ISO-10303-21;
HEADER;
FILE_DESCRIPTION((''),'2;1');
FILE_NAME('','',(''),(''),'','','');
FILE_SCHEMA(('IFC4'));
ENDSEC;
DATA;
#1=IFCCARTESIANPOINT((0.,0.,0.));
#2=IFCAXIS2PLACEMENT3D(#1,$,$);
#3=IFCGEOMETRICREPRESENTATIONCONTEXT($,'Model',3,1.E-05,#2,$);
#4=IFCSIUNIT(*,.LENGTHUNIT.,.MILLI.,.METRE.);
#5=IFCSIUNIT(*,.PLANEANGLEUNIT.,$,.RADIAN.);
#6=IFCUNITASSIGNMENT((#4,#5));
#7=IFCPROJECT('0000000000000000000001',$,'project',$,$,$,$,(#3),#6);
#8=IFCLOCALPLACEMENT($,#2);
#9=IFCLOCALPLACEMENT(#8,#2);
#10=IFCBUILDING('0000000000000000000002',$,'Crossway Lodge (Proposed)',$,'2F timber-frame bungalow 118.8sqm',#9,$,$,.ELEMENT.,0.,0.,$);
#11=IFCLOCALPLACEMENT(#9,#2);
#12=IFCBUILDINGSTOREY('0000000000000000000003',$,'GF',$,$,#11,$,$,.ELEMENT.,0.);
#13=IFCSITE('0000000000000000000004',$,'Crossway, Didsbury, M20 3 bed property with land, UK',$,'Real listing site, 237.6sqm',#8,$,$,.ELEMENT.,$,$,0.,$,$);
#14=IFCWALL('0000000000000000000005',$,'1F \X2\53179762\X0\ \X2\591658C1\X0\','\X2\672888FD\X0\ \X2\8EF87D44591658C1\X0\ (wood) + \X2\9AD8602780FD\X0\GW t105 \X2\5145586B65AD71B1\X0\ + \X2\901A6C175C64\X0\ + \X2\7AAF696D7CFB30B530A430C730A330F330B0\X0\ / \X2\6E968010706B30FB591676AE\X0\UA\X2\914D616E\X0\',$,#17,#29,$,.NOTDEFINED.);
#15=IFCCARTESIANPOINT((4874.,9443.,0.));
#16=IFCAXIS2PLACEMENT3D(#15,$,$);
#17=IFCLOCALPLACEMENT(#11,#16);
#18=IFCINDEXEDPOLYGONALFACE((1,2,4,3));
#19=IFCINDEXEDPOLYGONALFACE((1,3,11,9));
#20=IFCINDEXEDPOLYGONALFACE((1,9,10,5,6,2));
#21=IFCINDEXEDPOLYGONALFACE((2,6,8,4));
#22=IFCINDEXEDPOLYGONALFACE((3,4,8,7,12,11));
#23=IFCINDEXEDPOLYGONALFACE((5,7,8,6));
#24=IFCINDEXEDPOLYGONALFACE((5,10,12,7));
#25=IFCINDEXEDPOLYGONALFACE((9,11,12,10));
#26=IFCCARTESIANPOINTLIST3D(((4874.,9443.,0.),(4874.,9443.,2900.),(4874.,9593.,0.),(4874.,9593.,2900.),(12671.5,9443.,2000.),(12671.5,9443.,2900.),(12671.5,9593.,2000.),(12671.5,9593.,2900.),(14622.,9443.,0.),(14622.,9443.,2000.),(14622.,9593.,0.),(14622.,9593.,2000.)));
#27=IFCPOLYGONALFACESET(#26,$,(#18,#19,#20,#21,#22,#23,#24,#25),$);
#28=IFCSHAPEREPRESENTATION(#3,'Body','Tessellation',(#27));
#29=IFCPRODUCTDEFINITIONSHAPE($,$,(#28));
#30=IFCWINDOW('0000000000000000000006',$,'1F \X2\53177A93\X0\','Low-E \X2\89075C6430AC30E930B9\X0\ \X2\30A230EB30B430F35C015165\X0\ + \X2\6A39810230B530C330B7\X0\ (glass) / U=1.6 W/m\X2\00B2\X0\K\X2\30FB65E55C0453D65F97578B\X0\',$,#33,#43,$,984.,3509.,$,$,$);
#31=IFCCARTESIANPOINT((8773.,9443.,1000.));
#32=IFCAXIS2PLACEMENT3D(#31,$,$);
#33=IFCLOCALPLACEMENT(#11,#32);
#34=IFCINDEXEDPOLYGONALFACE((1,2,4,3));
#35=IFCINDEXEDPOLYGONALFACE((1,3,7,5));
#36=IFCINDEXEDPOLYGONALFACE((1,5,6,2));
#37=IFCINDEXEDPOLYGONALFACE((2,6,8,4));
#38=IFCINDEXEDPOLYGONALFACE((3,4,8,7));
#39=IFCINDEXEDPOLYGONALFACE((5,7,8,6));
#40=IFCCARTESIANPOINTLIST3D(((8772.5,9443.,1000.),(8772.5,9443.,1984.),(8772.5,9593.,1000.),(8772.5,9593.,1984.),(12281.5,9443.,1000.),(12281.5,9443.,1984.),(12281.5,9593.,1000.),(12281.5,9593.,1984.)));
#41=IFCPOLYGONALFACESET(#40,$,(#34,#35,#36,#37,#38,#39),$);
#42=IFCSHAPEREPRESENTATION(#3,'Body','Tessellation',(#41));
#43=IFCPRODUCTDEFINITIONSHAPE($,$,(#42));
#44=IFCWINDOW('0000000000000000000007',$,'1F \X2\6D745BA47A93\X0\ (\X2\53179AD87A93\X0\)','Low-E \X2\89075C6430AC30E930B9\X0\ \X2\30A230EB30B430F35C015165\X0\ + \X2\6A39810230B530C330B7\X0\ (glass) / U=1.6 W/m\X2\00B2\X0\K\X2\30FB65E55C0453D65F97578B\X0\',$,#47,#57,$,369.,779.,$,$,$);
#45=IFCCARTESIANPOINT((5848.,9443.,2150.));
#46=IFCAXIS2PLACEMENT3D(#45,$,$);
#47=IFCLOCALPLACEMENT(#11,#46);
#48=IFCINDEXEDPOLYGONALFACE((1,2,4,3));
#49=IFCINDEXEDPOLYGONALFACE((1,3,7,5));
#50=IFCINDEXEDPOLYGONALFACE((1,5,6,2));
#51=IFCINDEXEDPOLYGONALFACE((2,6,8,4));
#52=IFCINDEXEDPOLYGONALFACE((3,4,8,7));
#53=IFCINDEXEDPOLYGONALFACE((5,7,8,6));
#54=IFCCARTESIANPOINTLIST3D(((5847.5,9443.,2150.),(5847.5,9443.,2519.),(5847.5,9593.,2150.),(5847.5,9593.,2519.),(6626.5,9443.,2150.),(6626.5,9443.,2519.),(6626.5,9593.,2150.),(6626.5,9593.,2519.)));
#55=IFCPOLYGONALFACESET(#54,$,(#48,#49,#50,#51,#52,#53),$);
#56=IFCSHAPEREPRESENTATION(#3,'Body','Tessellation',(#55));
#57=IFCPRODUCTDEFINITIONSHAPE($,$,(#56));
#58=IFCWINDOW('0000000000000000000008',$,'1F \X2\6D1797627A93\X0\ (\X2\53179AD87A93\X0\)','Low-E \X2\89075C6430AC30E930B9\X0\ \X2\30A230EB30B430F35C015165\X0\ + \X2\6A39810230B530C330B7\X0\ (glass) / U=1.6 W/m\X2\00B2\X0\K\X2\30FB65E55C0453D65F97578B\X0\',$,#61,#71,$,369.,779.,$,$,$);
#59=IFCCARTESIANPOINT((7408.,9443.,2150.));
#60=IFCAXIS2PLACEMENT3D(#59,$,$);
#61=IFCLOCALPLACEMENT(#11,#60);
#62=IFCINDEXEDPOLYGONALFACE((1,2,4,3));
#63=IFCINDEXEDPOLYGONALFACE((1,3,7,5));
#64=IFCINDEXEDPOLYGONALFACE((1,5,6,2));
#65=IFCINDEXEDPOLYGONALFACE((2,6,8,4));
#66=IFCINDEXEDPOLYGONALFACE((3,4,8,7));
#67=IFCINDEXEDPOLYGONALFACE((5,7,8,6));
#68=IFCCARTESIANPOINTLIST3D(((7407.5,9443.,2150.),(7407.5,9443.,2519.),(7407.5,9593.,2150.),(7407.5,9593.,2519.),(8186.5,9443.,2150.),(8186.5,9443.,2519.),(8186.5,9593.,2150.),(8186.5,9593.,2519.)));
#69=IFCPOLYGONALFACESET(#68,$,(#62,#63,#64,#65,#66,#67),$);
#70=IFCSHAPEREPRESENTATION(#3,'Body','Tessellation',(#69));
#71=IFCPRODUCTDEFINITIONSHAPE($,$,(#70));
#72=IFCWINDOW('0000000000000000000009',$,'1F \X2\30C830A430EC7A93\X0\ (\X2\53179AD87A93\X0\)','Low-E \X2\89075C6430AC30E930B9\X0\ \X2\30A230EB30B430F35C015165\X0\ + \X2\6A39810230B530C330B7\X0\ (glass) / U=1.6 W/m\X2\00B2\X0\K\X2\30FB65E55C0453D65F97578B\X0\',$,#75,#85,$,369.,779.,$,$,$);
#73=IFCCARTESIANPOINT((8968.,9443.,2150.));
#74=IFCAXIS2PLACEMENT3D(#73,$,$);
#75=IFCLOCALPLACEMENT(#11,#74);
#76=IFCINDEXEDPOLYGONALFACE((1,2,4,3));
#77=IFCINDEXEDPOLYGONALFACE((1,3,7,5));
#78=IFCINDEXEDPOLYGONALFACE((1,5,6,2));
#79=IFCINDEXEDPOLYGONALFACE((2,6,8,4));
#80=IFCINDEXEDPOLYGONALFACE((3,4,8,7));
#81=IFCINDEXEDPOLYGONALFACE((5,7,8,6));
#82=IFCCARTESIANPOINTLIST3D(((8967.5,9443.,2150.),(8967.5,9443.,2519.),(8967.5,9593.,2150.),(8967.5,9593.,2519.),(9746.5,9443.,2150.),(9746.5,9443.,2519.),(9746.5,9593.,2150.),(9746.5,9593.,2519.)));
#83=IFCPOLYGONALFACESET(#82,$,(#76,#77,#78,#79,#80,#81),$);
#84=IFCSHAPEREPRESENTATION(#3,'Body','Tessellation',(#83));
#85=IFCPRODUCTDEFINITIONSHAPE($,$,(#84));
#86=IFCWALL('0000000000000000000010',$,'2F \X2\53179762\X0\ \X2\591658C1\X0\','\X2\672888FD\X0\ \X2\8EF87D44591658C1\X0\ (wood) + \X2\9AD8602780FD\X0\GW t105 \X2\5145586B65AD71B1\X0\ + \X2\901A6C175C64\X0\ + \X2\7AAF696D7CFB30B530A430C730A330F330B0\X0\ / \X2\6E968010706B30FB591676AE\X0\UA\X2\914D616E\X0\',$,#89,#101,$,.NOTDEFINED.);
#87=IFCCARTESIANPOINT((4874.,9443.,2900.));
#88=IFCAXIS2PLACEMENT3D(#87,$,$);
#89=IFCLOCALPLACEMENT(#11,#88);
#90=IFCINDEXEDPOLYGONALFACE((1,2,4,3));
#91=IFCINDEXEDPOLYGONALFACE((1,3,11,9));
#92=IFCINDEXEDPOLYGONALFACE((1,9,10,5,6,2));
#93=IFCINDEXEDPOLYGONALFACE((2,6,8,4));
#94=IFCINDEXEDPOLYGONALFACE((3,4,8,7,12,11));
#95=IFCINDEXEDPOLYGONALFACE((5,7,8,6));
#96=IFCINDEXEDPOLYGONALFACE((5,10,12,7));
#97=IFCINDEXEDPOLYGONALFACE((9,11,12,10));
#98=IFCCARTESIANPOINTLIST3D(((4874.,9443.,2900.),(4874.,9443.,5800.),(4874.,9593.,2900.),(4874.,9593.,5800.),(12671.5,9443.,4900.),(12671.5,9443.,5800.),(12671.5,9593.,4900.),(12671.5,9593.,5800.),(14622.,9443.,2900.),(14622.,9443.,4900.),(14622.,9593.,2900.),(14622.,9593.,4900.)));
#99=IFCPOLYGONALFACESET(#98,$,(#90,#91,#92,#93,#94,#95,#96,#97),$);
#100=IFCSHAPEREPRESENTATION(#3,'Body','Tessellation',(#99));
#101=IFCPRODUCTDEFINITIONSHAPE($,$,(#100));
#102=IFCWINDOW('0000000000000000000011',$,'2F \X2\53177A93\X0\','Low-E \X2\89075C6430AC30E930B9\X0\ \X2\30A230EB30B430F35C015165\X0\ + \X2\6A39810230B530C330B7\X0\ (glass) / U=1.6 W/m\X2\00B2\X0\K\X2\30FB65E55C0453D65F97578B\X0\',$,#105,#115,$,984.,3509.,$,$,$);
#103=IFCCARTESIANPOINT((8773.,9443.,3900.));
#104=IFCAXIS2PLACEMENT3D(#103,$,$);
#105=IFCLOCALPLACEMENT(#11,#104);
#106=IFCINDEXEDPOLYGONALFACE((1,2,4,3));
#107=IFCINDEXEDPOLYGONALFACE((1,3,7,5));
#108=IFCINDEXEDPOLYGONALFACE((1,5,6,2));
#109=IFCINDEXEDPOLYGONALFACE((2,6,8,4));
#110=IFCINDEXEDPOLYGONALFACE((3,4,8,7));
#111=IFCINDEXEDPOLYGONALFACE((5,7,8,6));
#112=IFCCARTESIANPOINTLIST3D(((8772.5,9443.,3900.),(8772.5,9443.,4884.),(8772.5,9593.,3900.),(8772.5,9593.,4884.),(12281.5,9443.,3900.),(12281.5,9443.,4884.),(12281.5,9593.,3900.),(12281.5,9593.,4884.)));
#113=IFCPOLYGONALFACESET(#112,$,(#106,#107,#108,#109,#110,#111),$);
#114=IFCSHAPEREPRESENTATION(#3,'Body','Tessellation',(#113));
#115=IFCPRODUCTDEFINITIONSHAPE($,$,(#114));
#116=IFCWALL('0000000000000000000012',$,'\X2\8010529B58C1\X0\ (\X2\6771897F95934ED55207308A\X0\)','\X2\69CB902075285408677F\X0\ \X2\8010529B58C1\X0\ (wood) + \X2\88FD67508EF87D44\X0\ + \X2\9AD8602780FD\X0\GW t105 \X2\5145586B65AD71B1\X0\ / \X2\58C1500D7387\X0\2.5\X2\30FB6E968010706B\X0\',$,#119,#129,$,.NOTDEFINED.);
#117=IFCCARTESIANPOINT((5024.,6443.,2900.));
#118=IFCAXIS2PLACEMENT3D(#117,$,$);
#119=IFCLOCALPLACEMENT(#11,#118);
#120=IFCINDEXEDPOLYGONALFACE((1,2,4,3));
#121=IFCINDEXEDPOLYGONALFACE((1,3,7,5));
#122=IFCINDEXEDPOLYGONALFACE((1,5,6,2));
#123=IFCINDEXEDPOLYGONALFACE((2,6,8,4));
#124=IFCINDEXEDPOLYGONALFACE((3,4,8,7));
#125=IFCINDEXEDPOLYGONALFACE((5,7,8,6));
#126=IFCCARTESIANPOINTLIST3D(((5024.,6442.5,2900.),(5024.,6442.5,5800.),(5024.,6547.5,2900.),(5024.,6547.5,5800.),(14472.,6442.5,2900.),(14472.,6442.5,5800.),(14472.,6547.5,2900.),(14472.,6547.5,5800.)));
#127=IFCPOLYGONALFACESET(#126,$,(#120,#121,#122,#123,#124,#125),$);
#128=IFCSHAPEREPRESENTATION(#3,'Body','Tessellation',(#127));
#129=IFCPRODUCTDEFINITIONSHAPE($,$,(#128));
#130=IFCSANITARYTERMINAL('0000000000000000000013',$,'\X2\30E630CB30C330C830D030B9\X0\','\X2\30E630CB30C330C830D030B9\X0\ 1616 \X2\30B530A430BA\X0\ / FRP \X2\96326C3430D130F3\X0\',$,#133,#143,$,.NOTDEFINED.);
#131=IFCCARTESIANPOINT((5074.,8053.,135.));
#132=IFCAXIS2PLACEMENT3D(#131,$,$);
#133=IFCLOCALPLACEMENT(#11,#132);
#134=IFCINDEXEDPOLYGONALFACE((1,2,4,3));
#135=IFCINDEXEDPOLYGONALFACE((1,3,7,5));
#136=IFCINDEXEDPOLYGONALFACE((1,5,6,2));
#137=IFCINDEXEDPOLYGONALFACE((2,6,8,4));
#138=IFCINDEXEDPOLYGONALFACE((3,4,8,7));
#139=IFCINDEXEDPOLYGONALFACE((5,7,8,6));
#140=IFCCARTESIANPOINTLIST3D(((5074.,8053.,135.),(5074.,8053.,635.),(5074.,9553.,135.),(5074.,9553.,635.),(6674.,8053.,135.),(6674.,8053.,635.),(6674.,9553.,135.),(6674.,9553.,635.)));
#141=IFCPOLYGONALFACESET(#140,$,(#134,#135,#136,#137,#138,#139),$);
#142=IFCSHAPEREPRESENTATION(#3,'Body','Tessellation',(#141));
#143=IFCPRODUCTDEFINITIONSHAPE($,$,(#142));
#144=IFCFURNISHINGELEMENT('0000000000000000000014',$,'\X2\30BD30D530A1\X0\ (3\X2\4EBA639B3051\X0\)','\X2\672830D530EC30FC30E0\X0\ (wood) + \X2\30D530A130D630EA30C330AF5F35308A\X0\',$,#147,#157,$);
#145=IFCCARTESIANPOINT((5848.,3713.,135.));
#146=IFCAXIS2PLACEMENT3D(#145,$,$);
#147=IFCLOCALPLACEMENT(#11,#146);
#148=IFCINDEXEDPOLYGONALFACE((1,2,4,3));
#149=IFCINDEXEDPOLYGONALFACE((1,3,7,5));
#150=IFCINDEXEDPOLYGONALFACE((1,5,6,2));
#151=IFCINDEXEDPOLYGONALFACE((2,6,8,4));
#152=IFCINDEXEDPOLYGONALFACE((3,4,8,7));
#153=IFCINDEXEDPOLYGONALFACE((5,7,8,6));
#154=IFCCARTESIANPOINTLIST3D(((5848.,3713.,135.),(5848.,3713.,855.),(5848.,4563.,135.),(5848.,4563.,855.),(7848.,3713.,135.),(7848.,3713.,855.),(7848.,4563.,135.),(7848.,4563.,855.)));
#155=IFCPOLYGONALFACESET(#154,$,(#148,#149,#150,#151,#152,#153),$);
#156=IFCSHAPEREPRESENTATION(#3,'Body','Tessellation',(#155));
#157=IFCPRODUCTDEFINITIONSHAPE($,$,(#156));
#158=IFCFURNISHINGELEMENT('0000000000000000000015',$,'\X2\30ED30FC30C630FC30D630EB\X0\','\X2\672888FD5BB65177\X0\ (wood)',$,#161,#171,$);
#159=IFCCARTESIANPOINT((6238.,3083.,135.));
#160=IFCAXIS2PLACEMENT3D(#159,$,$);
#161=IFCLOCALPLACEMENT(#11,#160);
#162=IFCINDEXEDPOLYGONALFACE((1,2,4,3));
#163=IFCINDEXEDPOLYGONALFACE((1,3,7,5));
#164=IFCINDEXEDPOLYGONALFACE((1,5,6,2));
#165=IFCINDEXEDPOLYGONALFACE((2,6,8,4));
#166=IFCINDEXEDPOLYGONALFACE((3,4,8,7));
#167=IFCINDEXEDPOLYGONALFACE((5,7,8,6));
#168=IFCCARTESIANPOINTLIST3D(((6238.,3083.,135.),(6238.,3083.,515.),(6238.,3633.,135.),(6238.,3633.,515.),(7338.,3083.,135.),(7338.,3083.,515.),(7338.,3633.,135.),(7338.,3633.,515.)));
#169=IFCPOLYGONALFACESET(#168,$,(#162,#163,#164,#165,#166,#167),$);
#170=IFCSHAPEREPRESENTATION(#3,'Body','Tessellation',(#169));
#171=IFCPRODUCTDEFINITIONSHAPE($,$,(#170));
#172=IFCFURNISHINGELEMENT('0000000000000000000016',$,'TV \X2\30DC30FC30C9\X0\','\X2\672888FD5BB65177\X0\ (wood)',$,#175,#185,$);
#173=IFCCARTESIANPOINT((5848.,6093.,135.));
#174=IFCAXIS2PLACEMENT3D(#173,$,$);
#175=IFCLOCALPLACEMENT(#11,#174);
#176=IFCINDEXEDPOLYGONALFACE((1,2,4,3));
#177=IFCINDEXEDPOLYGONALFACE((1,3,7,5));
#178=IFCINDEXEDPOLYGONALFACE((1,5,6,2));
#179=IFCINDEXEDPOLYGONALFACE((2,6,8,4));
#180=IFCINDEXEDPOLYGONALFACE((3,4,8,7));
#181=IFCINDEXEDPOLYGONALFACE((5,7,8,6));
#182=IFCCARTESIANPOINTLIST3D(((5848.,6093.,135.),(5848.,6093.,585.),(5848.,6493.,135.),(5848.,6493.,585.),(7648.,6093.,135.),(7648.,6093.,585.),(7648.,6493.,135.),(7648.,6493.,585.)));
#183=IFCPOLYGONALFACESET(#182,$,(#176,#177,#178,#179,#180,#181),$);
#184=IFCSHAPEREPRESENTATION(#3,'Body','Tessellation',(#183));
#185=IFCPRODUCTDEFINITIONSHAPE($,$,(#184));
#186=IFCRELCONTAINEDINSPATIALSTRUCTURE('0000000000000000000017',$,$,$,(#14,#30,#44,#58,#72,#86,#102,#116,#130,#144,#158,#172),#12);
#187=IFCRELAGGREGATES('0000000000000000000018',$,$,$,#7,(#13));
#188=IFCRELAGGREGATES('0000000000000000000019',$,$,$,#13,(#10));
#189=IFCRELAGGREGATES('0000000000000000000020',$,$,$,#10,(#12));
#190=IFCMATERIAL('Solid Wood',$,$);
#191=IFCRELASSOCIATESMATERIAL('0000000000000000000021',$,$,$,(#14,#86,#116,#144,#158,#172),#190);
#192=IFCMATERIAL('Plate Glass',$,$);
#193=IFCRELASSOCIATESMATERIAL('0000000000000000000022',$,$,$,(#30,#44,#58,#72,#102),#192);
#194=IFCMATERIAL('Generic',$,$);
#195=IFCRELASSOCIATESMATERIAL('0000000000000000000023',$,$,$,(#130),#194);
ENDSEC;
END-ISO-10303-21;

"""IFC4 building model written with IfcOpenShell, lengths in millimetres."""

from ifc_helpers import new_model, si_unit, frame, frame_2d, origin, place, context, project, spatial, rectangle, extrude, material, element, fill, save


model = new_model("IFC4")

# Units and contexts
model_context = context("Model", 3, precision=1e-05, world=origin())
ifc_project = project(units=[si_unit("LENGTHUNIT", "METRE", prefix="MILLI"), si_unit("PLANEANGLEUNIT", "RADIAN")], contexts=[model_context])

# Site, building, storey
site_placement = place(None, origin())
site = spatial("IfcSite", under=ifc_project, at=site_placement, Name="Crossway, Didsbury, M20 3 bed property with land, UK", ObjectType="Real listing site, 237.6sqm", CompositionType="ELEMENT", RefElevation=0.0)
building_placement = place(site_placement, origin())
building = spatial("IfcBuilding", under=site, at=building_placement, Name="Crossway Lodge (Proposed)", ObjectType="2F timber-frame bungalow 118.8sqm", CompositionType="ELEMENT", ElevationOfRefHeight=0.0, ElevationOfTerrain=0.0)
storey_placement = place(building_placement, origin())
storey = spatial("IfcBuildingStorey", under=building, at=storey_placement, Name="GF", CompositionType="ELEMENT", Elevation=0.0)

# Wall, openings, windows
ifc_material_1 = material(Name="Solid Wood")
wall_1_placement = place(storey_placement, frame((4874.0, 9443.0, 0.0)))
wall_1 = element("IfcWall", 1, at=wall_1_placement, inside=storey, material=ifc_material_1, Name="1F 北面 外壁", Description="木製 軸組外壁 (wood) + 高性能GW t105 充填断熱 + 通気層 + 窯業系サイディング / 準耐火・外皮UA配慮", PredefinedType="NOTDEFINED", context=model_context, shape_type="SweptSolid", body=[
    extrude(rectangle(XDim=9748.0, YDim=150.0, at=frame_2d((4874.0, 75.0))), frame((4874.0, 9443.0, 0.0)), (0.0, 0.0, 1.0), 2900.0),
])
opening_1_placement = place(storey_placement, frame((8773.0, 9443.0, 1000.0)))
opening_1 = element("IfcOpeningElement", 2, at=opening_1_placement, cuts=wall_1, PredefinedType="NOTDEFINED", context=model_context, shape_type="SweptSolid", body=[
    extrude(rectangle(XDim=3509.0, YDim=150.0, at=frame_2d((1754.0, 75.0))), frame((8773.0, 9443.0, 1000.0)), (0.0, 0.0, 1.0), 984.0),
])
opening_2_placement = place(storey_placement, frame((5848.0, 9443.0, 2150.0)))
opening_2 = element("IfcOpeningElement", 3, at=opening_2_placement, cuts=wall_1, PredefinedType="NOTDEFINED", context=model_context, shape_type="SweptSolid", body=[
    extrude(rectangle(XDim=779.0, YDim=150.0, at=frame_2d((389.0, 75.0))), frame((5848.0, 9443.0, 2150.0)), (0.0, 0.0, 1.0), 369.0),
])
opening_3_placement = place(storey_placement, frame((7408.0, 9443.0, 2150.0)))
opening_3 = element("IfcOpeningElement", 4, at=opening_3_placement, cuts=wall_1, PredefinedType="NOTDEFINED", context=model_context, shape_type="SweptSolid", body=[
    extrude(rectangle(XDim=779.0, YDim=150.0, at=frame_2d((389.0, 75.0))), frame((7408.0, 9443.0, 2150.0)), (0.0, 0.0, 1.0), 369.0),
])
opening_4_placement = place(storey_placement, frame((8968.0, 9443.0, 2150.0)))
opening_4 = element("IfcOpeningElement", 5, at=opening_4_placement, cuts=wall_1, PredefinedType="NOTDEFINED", context=model_context, shape_type="SweptSolid", body=[
    extrude(rectangle(XDim=779.0, YDim=150.0, at=frame_2d((389.0, 75.0))), frame((8968.0, 9443.0, 2150.0)), (0.0, 0.0, 1.0), 369.0),
])
ifc_material_2 = material(Name="Plate Glass")
window_1_placement = place(storey_placement, frame((8773.0, 9443.0, 1000.0)))
window_1 = element("IfcWindow", 6, at=window_1_placement, inside=storey, material=ifc_material_2, Name="1F 北窓", Description="Low-E 複層ガラス アルゴン封入 + 樹脂サッシ (glass) / U=1.6 W/m²K・日射取得型", OverallHeight=984.0, OverallWidth=3509.0, context=model_context, shape_type="SweptSolid", body=[
    extrude(rectangle(XDim=3509.0, YDim=150.0, at=frame_2d((1754.0, 75.0))), frame((8773.0, 9443.0, 1000.0)), (0.0, 0.0, 1.0), 984.0),
])
fill(opening_1, window_1)
window_2_placement = place(storey_placement, frame((5848.0, 9443.0, 2150.0)))
window_2 = element("IfcWindow", 7, at=window_2_placement, inside=storey, material=ifc_material_2, Name="1F 浴室窓 (北高窓)", Description="Low-E 複層ガラス アルゴン封入 + 樹脂サッシ (glass) / U=1.6 W/m²K・日射取得型", OverallHeight=369.0, OverallWidth=779.0, context=model_context, shape_type="SweptSolid", body=[
    extrude(rectangle(XDim=779.0, YDim=150.0, at=frame_2d((389.0, 75.0))), frame((5848.0, 9443.0, 2150.0)), (0.0, 0.0, 1.0), 369.0),
])
fill(opening_2, window_2)
window_3_placement = place(storey_placement, frame((7408.0, 9443.0, 2150.0)))
window_3 = element("IfcWindow", 8, at=window_3_placement, inside=storey, material=ifc_material_2, Name="1F 洗面窓 (北高窓)", Description="Low-E 複層ガラス アルゴン封入 + 樹脂サッシ (glass) / U=1.6 W/m²K・日射取得型", OverallHeight=369.0, OverallWidth=779.0, context=model_context, shape_type="SweptSolid", body=[
    extrude(rectangle(XDim=779.0, YDim=150.0, at=frame_2d((389.0, 75.0))), frame((7408.0, 9443.0, 2150.0)), (0.0, 0.0, 1.0), 369.0),
])
fill(opening_3, window_3)
window_4_placement = place(storey_placement, frame((8968.0, 9443.0, 2150.0)))
window_4 = element("IfcWindow", 9, at=window_4_placement, inside=storey, material=ifc_material_2, Name="1F トイレ窓 (北高窓)", Description="Low-E 複層ガラス アルゴン封入 + 樹脂サッシ (glass) / U=1.6 W/m²K・日射取得型", OverallHeight=369.0, OverallWidth=779.0, context=model_context, shape_type="SweptSolid", body=[
    extrude(rectangle(XDim=779.0, YDim=150.0, at=frame_2d((389.0, 75.0))), frame((8968.0, 9443.0, 2150.0)), (0.0, 0.0, 1.0), 369.0),
])
fill(opening_4, window_4)

# Wall, opening, window
wall_2_placement = place(storey_placement, frame((4874.0, 9443.0, 2900.0)))
wall_2 = element("IfcWall", 10, at=wall_2_placement, inside=storey, material=ifc_material_1, Name="2F 北面 外壁", Description="木製 軸組外壁 (wood) + 高性能GW t105 充填断熱 + 通気層 + 窯業系サイディング / 準耐火・外皮UA配慮", PredefinedType="NOTDEFINED", context=model_context, shape_type="SweptSolid", body=[
    extrude(rectangle(XDim=9748.0, YDim=150.0, at=frame_2d((4874.0, 75.0))), frame((4874.0, 9443.0, 2900.0)), (0.0, 0.0, 1.0), 2900.0),
])
opening_5_placement = place(storey_placement, frame((8773.0, 9443.0, 3900.0)))
opening_5 = element("IfcOpeningElement", 11, at=opening_5_placement, cuts=wall_2, PredefinedType="NOTDEFINED", context=model_context, shape_type="SweptSolid", body=[
    extrude(rectangle(XDim=3509.0, YDim=150.0, at=frame_2d((1754.0, 75.0))), frame((8773.0, 9443.0, 3900.0)), (0.0, 0.0, 1.0), 984.0),
])
window_5_placement = place(storey_placement, frame((8773.0, 9443.0, 3900.0)))
window_5 = element("IfcWindow", 12, at=window_5_placement, inside=storey, material=ifc_material_2, Name="2F 北窓", Description="Low-E 複層ガラス アルゴン封入 + 樹脂サッシ (glass) / U=1.6 W/m²K・日射取得型", OverallHeight=984.0, OverallWidth=3509.0, context=model_context, shape_type="SweptSolid", body=[
    extrude(rectangle(XDim=3509.0, YDim=150.0, at=frame_2d((1754.0, 75.0))), frame((8773.0, 9443.0, 3900.0)), (0.0, 0.0, 1.0), 984.0),
])
fill(opening_5, window_5)

# Wall
wall_3_placement = place(storey_placement, frame((5024.0, 6443.0, 2900.0)))
element("IfcWall", 13, at=wall_3_placement, inside=storey, material=ifc_material_1, Name="耐力壁 (東西間仕切り)", Description="構造用合板 耐力壁 (wood) + 製材軸組 + 高性能GW t105 充填断熱 / 壁倍率2.5・準耐火", PredefinedType="NOTDEFINED", context=model_context, shape_type="SweptSolid", body=[
    extrude(rectangle(XDim=9448.0, YDim=105.0, at=frame_2d((4724.0, 52.0))), frame((5024.0, 6443.0, 2900.0)), (0.0, 0.0, 1.0), 2900.0),
])

# Sanitary terminal
ifc_material_3 = material(Name="Generic")
sanitary_terminal_placement = place(storey_placement, frame((5074.0, 8053.0, 135.0)))
element("IfcSanitaryTerminal", 14, at=sanitary_terminal_placement, inside=storey, material=ifc_material_3, Name="ユニットバス", Description="ユニットバス 1616 サイズ / FRP 防水パン", PredefinedType="NOTDEFINED", context=model_context, shape_type="SweptSolid", body=[
    extrude(rectangle(XDim=1600.0, YDim=1500.0, at=frame_2d((800.0, 750.0))), frame((5074.0, 8053.0, 135.0)), (0.0, 0.0, 1.0), 500.0),
])

# Furnishing elements
furnishing_1_placement = place(storey_placement, frame((5848.0, 3713.0, 135.0)))
element("IfcFurnishingElement", 15, at=furnishing_1_placement, inside=storey, material=ifc_material_1, Name="ソファ (3人掛け)", Description="木フレーム (wood) + ファブリック張り", context=model_context, shape_type="SweptSolid", body=[
    extrude(rectangle(XDim=2000.0, YDim=850.0, at=frame_2d((1000.0, 425.0))), frame((5848.0, 3713.0, 135.0)), (0.0, 0.0, 1.0), 720.0),
])
furnishing_2_placement = place(storey_placement, frame((6238.0, 3083.0, 135.0)))
element("IfcFurnishingElement", 16, at=furnishing_2_placement, inside=storey, material=ifc_material_1, Name="ローテーブル", Description="木製家具 (wood)", context=model_context, shape_type="SweptSolid", body=[
    extrude(rectangle(XDim=1100.0, YDim=550.0, at=frame_2d((550.0, 275.0))), frame((6238.0, 3083.0, 135.0)), (0.0, 0.0, 1.0), 380.0),
])
furnishing_3_placement = place(storey_placement, frame((5848.0, 6093.0, 135.0)))
element("IfcFurnishingElement", 17, at=furnishing_3_placement, inside=storey, material=ifc_material_1, Name="TV ボード", Description="木製家具 (wood)", context=model_context, shape_type="SweptSolid", body=[
    extrude(rectangle(XDim=1800.0, YDim=400.0, at=frame_2d((900.0, 200.0))), frame((5848.0, 6093.0, 135.0)), (0.0, 0.0, 1.0), 450.0),
])

save(model, "model.ifc")
